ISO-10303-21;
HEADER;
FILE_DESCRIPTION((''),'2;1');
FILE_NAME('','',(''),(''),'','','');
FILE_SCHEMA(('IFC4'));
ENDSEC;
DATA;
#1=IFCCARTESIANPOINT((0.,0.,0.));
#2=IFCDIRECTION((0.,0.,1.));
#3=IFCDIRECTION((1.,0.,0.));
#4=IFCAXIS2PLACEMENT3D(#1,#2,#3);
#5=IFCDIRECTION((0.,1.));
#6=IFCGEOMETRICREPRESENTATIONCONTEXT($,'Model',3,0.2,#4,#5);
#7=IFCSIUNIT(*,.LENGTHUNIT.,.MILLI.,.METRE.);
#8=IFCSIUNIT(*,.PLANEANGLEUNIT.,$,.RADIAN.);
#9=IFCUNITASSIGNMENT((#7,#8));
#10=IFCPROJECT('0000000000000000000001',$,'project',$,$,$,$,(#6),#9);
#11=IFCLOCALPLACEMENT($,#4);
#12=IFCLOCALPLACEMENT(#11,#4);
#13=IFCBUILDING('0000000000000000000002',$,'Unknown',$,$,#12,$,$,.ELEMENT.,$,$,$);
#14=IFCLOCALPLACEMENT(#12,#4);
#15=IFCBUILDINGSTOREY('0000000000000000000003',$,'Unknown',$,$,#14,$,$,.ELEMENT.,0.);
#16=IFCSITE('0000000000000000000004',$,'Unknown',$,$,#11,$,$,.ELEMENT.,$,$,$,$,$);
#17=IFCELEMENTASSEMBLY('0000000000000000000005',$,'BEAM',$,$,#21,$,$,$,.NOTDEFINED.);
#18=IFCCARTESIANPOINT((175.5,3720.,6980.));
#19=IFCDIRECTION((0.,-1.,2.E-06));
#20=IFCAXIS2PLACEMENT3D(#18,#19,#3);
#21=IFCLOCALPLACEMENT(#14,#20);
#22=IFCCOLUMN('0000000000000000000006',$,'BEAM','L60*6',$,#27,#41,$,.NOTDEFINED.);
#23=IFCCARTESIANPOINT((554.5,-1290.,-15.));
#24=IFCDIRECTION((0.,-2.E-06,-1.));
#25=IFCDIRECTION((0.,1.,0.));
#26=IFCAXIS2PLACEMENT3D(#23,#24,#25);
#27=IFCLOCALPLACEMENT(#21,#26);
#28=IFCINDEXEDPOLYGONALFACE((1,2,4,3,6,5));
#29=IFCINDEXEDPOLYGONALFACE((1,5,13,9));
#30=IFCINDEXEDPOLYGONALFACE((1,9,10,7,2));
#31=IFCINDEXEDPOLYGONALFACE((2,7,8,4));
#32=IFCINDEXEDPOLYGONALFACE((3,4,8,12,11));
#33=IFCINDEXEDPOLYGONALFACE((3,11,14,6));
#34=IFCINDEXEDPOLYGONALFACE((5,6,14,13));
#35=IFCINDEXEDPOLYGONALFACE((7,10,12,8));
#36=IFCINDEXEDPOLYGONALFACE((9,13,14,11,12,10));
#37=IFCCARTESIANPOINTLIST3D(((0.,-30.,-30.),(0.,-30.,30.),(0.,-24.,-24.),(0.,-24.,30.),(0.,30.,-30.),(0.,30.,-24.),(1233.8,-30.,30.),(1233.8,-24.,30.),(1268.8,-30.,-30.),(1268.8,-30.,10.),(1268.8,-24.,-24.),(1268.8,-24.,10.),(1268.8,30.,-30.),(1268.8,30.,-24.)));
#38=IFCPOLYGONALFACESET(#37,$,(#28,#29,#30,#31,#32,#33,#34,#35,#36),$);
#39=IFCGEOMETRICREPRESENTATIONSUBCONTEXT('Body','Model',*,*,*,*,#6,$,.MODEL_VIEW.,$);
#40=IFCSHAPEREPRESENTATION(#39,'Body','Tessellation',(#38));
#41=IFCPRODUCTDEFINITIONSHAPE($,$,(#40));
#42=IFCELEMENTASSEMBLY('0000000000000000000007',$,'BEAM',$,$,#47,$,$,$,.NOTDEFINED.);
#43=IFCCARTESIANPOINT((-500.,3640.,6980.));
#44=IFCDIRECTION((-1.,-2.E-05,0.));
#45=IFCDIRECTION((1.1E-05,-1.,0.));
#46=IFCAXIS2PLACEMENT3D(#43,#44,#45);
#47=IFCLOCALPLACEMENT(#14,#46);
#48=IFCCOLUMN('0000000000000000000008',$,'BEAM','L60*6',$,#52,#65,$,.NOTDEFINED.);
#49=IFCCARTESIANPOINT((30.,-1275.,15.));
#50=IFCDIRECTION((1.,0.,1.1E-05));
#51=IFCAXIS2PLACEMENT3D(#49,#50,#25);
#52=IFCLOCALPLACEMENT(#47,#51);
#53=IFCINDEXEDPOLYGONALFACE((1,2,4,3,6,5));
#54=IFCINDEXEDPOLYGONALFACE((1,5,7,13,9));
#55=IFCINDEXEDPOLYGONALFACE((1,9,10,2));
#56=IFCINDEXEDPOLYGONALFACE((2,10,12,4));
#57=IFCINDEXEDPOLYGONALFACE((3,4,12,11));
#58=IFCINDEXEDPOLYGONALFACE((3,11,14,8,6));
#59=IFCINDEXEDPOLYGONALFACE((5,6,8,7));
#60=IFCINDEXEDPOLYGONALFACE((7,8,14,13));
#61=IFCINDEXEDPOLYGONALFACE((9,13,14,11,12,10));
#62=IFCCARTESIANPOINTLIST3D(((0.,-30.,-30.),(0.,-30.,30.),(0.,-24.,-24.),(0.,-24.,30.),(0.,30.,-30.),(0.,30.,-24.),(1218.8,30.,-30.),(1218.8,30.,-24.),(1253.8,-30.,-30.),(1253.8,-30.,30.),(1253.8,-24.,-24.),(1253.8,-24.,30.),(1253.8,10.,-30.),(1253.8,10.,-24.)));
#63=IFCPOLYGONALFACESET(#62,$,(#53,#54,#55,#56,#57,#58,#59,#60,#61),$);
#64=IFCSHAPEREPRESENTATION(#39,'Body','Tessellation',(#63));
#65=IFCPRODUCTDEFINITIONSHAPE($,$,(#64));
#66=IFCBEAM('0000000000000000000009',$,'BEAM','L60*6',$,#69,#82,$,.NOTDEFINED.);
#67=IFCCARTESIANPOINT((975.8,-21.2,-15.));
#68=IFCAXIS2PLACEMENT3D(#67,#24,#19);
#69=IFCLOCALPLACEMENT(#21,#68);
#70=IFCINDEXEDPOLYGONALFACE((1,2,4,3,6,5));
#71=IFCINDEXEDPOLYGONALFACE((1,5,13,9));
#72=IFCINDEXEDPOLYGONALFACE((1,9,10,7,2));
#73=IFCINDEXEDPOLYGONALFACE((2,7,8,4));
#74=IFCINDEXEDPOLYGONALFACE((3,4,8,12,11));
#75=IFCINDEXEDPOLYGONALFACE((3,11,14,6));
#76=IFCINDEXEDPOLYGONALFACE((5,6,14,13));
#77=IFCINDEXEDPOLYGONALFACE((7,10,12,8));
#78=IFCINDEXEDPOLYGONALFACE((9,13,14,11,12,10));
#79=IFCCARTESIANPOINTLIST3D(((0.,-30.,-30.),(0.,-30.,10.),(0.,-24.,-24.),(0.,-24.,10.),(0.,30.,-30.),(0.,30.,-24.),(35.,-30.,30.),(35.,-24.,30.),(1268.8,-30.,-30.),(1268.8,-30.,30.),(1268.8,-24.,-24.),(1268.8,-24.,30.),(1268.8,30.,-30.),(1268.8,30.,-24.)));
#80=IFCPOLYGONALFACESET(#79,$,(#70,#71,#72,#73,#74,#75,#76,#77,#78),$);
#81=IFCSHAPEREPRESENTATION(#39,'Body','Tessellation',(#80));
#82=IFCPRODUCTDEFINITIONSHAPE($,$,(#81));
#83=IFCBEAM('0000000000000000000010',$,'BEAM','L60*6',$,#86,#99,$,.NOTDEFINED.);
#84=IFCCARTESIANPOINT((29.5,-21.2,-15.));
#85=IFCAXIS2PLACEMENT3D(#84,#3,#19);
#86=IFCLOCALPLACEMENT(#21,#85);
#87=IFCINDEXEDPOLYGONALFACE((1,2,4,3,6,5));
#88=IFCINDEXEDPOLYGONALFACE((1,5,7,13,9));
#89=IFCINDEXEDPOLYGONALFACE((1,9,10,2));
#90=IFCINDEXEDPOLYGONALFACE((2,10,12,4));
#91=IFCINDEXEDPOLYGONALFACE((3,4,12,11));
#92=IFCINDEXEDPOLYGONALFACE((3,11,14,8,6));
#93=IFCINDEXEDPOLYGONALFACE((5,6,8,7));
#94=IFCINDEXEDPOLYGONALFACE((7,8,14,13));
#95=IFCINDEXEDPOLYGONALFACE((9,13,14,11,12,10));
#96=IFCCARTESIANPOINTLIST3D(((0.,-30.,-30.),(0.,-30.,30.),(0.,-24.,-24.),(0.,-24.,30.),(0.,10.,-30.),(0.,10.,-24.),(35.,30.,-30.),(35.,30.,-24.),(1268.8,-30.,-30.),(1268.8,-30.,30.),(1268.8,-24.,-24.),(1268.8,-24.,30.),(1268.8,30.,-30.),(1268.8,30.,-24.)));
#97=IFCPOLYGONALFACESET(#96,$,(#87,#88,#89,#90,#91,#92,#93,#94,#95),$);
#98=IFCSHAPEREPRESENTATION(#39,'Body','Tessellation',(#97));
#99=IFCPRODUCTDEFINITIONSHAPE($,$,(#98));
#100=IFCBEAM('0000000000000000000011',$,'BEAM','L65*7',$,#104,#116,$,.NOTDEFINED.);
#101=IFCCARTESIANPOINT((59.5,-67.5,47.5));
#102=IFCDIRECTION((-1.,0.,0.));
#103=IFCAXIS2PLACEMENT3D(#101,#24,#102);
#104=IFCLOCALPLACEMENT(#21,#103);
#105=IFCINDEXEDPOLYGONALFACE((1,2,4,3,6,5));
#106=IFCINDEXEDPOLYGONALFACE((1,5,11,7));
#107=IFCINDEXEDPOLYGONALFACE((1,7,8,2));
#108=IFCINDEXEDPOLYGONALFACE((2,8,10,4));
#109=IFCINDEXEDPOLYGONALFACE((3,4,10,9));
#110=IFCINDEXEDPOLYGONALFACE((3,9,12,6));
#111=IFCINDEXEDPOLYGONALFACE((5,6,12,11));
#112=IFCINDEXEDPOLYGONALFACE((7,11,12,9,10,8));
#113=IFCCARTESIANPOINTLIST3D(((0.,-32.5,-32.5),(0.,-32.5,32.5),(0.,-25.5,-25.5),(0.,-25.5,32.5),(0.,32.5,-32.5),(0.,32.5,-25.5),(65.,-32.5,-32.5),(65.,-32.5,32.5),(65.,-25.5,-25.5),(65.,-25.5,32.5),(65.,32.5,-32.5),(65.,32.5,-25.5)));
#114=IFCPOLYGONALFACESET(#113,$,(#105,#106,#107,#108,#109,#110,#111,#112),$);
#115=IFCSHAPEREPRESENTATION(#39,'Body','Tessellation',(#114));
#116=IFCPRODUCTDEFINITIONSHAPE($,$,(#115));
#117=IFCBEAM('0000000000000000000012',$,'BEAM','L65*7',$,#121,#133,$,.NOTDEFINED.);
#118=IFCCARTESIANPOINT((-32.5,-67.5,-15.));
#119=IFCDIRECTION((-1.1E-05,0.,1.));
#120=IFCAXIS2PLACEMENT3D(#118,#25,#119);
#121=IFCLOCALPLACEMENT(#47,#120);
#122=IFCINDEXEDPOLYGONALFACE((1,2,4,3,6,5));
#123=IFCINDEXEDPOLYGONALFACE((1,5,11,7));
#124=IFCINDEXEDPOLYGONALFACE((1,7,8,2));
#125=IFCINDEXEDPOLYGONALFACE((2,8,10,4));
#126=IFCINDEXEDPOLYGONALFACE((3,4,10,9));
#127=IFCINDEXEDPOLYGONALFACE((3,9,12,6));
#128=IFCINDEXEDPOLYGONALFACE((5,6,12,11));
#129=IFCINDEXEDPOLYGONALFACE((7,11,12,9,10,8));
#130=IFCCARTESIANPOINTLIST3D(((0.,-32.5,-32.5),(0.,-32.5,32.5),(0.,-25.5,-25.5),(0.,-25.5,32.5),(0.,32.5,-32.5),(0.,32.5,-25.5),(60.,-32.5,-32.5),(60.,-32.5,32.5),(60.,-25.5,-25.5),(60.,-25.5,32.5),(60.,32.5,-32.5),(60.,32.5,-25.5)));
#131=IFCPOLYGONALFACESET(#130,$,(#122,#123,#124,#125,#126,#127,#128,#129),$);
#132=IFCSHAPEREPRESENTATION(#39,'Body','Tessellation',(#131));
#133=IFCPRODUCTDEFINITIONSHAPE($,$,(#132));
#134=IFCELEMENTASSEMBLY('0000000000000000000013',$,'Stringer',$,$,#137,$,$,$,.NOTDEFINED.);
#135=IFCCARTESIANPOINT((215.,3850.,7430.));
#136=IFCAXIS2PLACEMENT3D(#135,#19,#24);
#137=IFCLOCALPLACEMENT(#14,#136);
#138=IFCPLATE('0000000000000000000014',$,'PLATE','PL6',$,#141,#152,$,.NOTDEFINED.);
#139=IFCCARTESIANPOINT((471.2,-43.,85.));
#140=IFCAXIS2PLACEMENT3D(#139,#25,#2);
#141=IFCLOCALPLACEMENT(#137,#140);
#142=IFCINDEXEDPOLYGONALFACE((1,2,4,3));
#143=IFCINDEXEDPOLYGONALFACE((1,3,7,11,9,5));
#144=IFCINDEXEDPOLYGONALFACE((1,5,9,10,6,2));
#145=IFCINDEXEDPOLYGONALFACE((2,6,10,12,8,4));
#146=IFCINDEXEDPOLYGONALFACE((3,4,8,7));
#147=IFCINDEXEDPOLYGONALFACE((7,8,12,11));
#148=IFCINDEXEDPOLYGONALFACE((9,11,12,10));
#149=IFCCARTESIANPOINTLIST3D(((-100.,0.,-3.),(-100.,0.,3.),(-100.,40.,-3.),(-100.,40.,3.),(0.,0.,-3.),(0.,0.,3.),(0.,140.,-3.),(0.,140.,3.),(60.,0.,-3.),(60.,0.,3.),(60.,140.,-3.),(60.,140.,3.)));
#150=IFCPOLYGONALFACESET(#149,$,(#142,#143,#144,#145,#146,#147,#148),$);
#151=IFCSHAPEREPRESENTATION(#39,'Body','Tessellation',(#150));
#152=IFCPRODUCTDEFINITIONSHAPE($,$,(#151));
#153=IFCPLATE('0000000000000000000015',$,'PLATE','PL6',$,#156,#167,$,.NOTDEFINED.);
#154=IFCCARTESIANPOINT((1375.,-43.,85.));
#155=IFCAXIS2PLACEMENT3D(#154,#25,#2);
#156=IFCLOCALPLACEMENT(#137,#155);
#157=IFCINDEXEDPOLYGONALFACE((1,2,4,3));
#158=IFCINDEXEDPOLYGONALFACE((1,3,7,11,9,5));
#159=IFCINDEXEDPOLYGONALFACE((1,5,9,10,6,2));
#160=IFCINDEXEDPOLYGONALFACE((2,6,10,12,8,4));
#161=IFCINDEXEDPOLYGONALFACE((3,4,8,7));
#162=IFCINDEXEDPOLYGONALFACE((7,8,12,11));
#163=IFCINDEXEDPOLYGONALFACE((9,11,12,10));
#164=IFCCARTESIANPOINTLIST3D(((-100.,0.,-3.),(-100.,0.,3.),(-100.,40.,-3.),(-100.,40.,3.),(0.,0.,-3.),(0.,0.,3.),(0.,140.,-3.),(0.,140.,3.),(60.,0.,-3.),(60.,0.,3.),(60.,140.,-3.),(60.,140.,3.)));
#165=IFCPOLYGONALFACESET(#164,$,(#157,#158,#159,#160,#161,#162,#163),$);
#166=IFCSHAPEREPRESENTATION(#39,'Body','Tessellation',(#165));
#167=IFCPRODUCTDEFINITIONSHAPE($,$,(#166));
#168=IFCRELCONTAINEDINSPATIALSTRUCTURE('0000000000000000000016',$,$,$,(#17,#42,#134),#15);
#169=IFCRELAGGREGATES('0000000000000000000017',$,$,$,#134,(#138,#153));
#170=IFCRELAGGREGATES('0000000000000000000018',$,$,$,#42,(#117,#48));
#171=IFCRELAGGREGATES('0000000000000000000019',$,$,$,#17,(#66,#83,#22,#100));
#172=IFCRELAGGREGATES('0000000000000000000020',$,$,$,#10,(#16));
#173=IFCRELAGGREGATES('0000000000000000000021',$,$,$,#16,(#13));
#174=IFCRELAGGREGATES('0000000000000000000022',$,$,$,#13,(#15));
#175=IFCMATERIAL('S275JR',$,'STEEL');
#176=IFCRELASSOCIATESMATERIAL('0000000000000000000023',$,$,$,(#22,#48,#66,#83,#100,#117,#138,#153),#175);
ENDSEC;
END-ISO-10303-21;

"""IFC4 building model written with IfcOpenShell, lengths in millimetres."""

from ifc_helpers import new_model, si_unit, direction, frame, origin_with_axes, place, context, subcontext, project, spatial, line, indexed_curve, outline, extrude, material, element, aggregate, save


model = new_model("IFC4")

# Units and contexts
model_context = context("Model", 3, precision=0.2, world=origin_with_axes(), true_north=direction((0.0, 1.0)))
body_context = subcontext(model_context, "Body", "Model", "MODEL_VIEW")
ifc_project = project(units=[si_unit("LENGTHUNIT", "METRE", prefix="MILLI"), si_unit("PLANEANGLEUNIT", "RADIAN")], contexts=[model_context])

# Site, building, storey
site_placement = place(None, origin_with_axes())
site = spatial("IfcSite", under=ifc_project, at=site_placement, Name="Unknown", CompositionType="ELEMENT")
building_placement = place(site_placement, origin_with_axes())
building = spatial("IfcBuilding", under=site, at=building_placement, Name="Unknown", CompositionType="ELEMENT")
storey_placement = place(building_placement, origin_with_axes())
storey = spatial("IfcBuildingStorey", under=building, at=storey_placement, Name="Unknown", CompositionType="ELEMENT", Elevation=0.0)

# Element assemblies, columns, voiding features
assembly_1_placement = place(storey_placement, frame((175.5, 3720.0, 6980.0), z_axis=(0.0, -1.0, 0.000002), x_axis=(1.0, 0.0, 0.0)))
assembly_1 = element("IfcElementAssembly", 1, at=assembly_1_placement, inside=storey, Name="BEAM", PredefinedType="NOTDEFINED")
ifc_material_1 = material(Name="S275JR", Category="STEEL")
column_1_placement = place(assembly_1_placement, frame((554.5, -1290.0, -15.0), z_axis=(0.0, -0.000002, -1.0), x_axis=(0.0, 1.0, 0.0)))
column_1 = element("IfcColumn", 2, at=column_1_placement, material=ifc_material_1, Name="BEAM", Description="L60*6", PredefinedType="NOTDEFINED", context=body_context, shape_type="SolidModel", body=[
    extrude(outline(indexed_curve([(-30.0, -30.0), (30.0, -30.0), (30.0, -24.0), (-24.0, -24.0), (-24.0, 30.0), (-30.0, 30.0)], segments=[line(1, 2, 3, 4, 5, 6, 1)])), frame((0.0, 0.0, 0.0), z_axis=(-1.0, 0.0, 0.0), x_axis=(0.0, 0.0, 1.0)), (0.0, -0.000002, -1.0), 1268.8),
])
voiding_feature_1_placement = place(column_1_placement, frame((1268.8, 0.0, 10.0), z_axis=(0.0, -1.0, 0.000002), x_axis=(0.0, 0.0, 1.0)))
element("IfcVoidingFeature", 3, at=voiding_feature_1_placement, cuts=column_1, Name="CUTPART", PredefinedType="HOLE", context=body_context, shape_type="SolidModel", body=[
    extrude(outline(indexed_curve([(0.0, 0.0), (20.0, 0.0), (20.0, 35.0)], segments=[line(1, 2, 3, 1)])), frame((0.0, 0.0, 33.0), z_axis=(0.0, 0.0, 1.0), x_axis=(1.0, 0.0, 0.0)), (0.0, -0.000002, -1.0), 66.0),
])
assembly_2_placement = place(storey_placement, frame((-500.0, 3640.0, 6980.0), z_axis=(-1.0, -0.00002, 0.0), x_axis=(0.000011, -1.0, 0.0)))
assembly_2 = element("IfcElementAssembly", 4, at=assembly_2_placement, inside=storey, Name="BEAM", PredefinedType="NOTDEFINED")
column_2_placement = place(assembly_2_placement, frame((30.0, -1275.0, 15.0), z_axis=(1.0, 0.0, 0.000011), x_axis=(0.0, 1.0, 0.0)))
column_2 = element("IfcColumn", 5, at=column_2_placement, material=ifc_material_1, Name="BEAM", Description="L60*6", PredefinedType="NOTDEFINED", context=body_context, shape_type="SolidModel", body=[
    extrude(outline(indexed_curve([(-30.0, -30.0), (30.0, -30.0), (30.0, -24.0), (-24.0, -24.0), (-24.0, 30.0), (-30.0, 30.0)], segments=[line(1, 2, 3, 4, 5, 6, 1)])), frame((0.0, 0.0, 0.0), z_axis=(-1.0, 0.0, 0.0), x_axis=(0.0, 0.0, 1.0)), (0.0, -0.000002, -1.0), 1253.8),
])
voiding_feature_2_placement = place(column_2_placement, frame((1253.8, 10.0, 0.0), z_axis=(0.0, 0.0, 1.0), x_axis=(0.0, 1.0, 0.0)))
element("IfcVoidingFeature", 6, at=voiding_feature_2_placement, cuts=column_2, Name="CUTPART", PredefinedType="HOLE", context=body_context, shape_type="SolidModel", body=[
    extrude(outline(indexed_curve([(0.0, 0.0), (20.0, 0.0), (20.0, 35.0)], segments=[line(1, 2, 3, 1)])), frame((0.0, 0.0, 33.0), z_axis=(0.0, 0.0, 1.0), x_axis=(1.0, 0.0, 0.0)), (0.0, -0.000002, -1.0), 66.0),
])

# Beams, voiding features
beam_1_placement = place(assembly_1_placement, frame((975.8, -21.2, -15.0), z_axis=(0.0, -0.000002, -1.0), x_axis=(0.0, -1.0, 0.000002)))
beam_1 = element("IfcBeam", 7, at=beam_1_placement, material=ifc_material_1, Name="BEAM", Description="L60*6", PredefinedType="NOTDEFINED", context=body_context, shape_type="SolidModel", body=[
    extrude(outline(indexed_curve([(-30.0, -30.0), (30.0, -30.0), (30.0, -24.0), (-24.0, -24.0), (-24.0, 30.0), (-30.0, 30.0)], segments=[line(1, 2, 3, 4, 5, 6, 1)])), frame((0.0, 0.0, 0.0), z_axis=(-1.0, 0.0, 0.0), x_axis=(0.0, 0.0, 1.0)), (0.0, -0.000002, -1.0), 1268.8),
])
voiding_feature_3_placement = place(beam_1_placement, frame((0.0, 0.0, 10.0), z_axis=(0.0, 1.0, 0.0), x_axis=(0.0, 0.0, 1.0)))
element("IfcVoidingFeature", 8, at=voiding_feature_3_placement, cuts=beam_1, Name="CUTPART", PredefinedType="HOLE", context=body_context, shape_type="SolidModel", body=[
    extrude(outline(indexed_curve([(0.0, 0.0), (20.0, 0.0), (20.0, 35.0)], segments=[line(1, 2, 3, 1)])), frame((0.0, 0.0, 33.0), z_axis=(0.0, 0.0, 1.0), x_axis=(1.0, 0.0, 0.0)), (0.0, -0.000002, -1.0), 66.0),
])
beam_2_placement = place(assembly_1_placement, frame((29.5, -21.2, -15.0), z_axis=(1.0, 0.0, 0.0), x_axis=(0.0, -1.0, 0.000002)))
beam_2 = element("IfcBeam", 9, at=beam_2_placement, material=ifc_material_1, Name="BEAM", Description="L60*6", PredefinedType="NOTDEFINED", context=body_context, shape_type="SolidModel", body=[
    extrude(outline(indexed_curve([(-30.0, -30.0), (30.0, -30.0), (30.0, -24.0), (-24.0, -24.0), (-24.0, 30.0), (-30.0, 30.0)], segments=[line(1, 2, 3, 4, 5, 6, 1)])), frame((0.0, 0.0, 0.0), z_axis=(-1.0, 0.0, 0.0), x_axis=(0.0, 0.0, 1.0)), (0.0, -0.000002, -1.0), 1268.8),
])
voiding_feature_4_placement = place(beam_2_placement, frame((0.0, 10.0, 0.0), z_axis=(0.0, -0.000002, -1.0), x_axis=(0.0, 1.0, 0.0)))
element("IfcVoidingFeature", 10, at=voiding_feature_4_placement, cuts=beam_2, Name="CUTPART", PredefinedType="HOLE", context=body_context, shape_type="SolidModel", body=[
    extrude(outline(indexed_curve([(0.0, 0.0), (20.0, 0.0), (20.0, 35.0)], segments=[line(1, 2, 3, 1)])), frame((0.0, 0.0, 33.0), z_axis=(0.0, 0.0, 1.0), x_axis=(1.0, 0.0, 0.0)), (0.0, -0.000002, -1.0), 66.0),
])

# Beams
beam_3_placement = place(assembly_1_placement, frame((59.5, -67.5, 47.5), z_axis=(0.0, -0.000002, -1.0), x_axis=(-1.0, 0.0, 0.0)))
beam_3 = element("IfcBeam", 11, at=beam_3_placement, material=ifc_material_1, Name="BEAM", Description="L65*7", PredefinedType="NOTDEFINED", context=body_context, shape_type="SolidModel", body=[
    extrude(outline(indexed_curve([(-32.5, -32.5), (32.5, -32.5), (32.5, -25.5), (-25.5, -25.5), (-25.5, 32.5), (-32.5, 32.5)], segments=[line(1, 2, 3, 4, 5, 6, 1)])), frame((0.0, 0.0, 0.0), z_axis=(-1.0, 0.0, 0.0), x_axis=(0.0, 0.0, 1.0)), (0.0, -0.000002, -1.0), 65.0),
])
beam_4_placement = place(assembly_2_placement, frame((-32.5, -67.5, -15.0), z_axis=(0.0, 1.0, 0.0), x_axis=(-0.000011, 0.0, 1.0)))
beam_4 = element("IfcBeam", 12, at=beam_4_placement, material=ifc_material_1, Name="BEAM", Description="L65*7", PredefinedType="NOTDEFINED", context=body_context, shape_type="SolidModel", body=[
    extrude(outline(indexed_curve([(-32.5, -32.5), (32.5, -32.5), (32.5, -25.5), (-25.5, -25.5), (-25.5, 32.5), (-32.5, 32.5)], segments=[line(1, 2, 3, 4, 5, 6, 1)])), frame((0.0, 0.0, 0.0), z_axis=(-1.0, 0.0, 0.0), x_axis=(0.0, 0.0, 1.0)), (0.0, -0.000002, -1.0), 60.0),
])

# Element assembly, plates
assembly_3_placement = place(storey_placement, frame((215.0, 3850.0, 7430.0), z_axis=(0.0, -1.0, 0.000002), x_axis=(0.0, -0.000002, -1.0)))
assembly_3 = element("IfcElementAssembly", 13, at=assembly_3_placement, inside=storey, Name="Stringer", PredefinedType="NOTDEFINED")
plate_1_placement = place(assembly_3_placement, frame((471.2, -43.0, 85.0), z_axis=(0.0, 1.0, 0.0), x_axis=(0.0, 0.0, 1.0)))
plate_1 = element("IfcPlate", 14, at=plate_1_placement, material=ifc_material_1, Name="PLATE", Description="PL6", PredefinedType="NOTDEFINED", context=body_context, shape_type="SolidModel", body=[
    extrude(outline(indexed_curve([(0.0, 0.0), (60.0, 0.0), (60.0, 140.0), (0.0, 140.0), (-100.0, 40.0), (-100.0, 0.0)], segments=[line(1, 2, 3, 4, 5, 6, 1)])), frame((0.0, 0.0, 3.0), z_axis=(0.0, 0.0, 1.0), x_axis=(1.0, 0.0, 0.0)), (0.0, -0.000002, -1.0), 6.0),
])
plate_2_placement = place(assembly_3_placement, frame((1375.0, -43.0, 85.0), z_axis=(0.0, 1.0, 0.0), x_axis=(0.0, 0.0, 1.0)))
plate_2 = element("IfcPlate", 15, at=plate_2_placement, material=ifc_material_1, Name="PLATE", Description="PL6", PredefinedType="NOTDEFINED", context=body_context, shape_type="SolidModel", body=[
    extrude(outline(indexed_curve([(0.0, 0.0), (60.0, 0.0), (60.0, 140.0), (0.0, 140.0), (-100.0, 40.0), (-100.0, 0.0)], segments=[line(1, 2, 3, 4, 5, 6, 1)])), frame((0.0, 0.0, 3.0), z_axis=(0.0, 0.0, 1.0), x_axis=(1.0, 0.0, 0.0)), (0.0, -0.000002, -1.0), 6.0),
])
aggregate(assembly_3, [plate_1, plate_2])

aggregate(assembly_2, [beam_4, column_2])
aggregate(assembly_1, [beam_1, beam_2, column_1, beam_3])

save(model, "model.ifc")
